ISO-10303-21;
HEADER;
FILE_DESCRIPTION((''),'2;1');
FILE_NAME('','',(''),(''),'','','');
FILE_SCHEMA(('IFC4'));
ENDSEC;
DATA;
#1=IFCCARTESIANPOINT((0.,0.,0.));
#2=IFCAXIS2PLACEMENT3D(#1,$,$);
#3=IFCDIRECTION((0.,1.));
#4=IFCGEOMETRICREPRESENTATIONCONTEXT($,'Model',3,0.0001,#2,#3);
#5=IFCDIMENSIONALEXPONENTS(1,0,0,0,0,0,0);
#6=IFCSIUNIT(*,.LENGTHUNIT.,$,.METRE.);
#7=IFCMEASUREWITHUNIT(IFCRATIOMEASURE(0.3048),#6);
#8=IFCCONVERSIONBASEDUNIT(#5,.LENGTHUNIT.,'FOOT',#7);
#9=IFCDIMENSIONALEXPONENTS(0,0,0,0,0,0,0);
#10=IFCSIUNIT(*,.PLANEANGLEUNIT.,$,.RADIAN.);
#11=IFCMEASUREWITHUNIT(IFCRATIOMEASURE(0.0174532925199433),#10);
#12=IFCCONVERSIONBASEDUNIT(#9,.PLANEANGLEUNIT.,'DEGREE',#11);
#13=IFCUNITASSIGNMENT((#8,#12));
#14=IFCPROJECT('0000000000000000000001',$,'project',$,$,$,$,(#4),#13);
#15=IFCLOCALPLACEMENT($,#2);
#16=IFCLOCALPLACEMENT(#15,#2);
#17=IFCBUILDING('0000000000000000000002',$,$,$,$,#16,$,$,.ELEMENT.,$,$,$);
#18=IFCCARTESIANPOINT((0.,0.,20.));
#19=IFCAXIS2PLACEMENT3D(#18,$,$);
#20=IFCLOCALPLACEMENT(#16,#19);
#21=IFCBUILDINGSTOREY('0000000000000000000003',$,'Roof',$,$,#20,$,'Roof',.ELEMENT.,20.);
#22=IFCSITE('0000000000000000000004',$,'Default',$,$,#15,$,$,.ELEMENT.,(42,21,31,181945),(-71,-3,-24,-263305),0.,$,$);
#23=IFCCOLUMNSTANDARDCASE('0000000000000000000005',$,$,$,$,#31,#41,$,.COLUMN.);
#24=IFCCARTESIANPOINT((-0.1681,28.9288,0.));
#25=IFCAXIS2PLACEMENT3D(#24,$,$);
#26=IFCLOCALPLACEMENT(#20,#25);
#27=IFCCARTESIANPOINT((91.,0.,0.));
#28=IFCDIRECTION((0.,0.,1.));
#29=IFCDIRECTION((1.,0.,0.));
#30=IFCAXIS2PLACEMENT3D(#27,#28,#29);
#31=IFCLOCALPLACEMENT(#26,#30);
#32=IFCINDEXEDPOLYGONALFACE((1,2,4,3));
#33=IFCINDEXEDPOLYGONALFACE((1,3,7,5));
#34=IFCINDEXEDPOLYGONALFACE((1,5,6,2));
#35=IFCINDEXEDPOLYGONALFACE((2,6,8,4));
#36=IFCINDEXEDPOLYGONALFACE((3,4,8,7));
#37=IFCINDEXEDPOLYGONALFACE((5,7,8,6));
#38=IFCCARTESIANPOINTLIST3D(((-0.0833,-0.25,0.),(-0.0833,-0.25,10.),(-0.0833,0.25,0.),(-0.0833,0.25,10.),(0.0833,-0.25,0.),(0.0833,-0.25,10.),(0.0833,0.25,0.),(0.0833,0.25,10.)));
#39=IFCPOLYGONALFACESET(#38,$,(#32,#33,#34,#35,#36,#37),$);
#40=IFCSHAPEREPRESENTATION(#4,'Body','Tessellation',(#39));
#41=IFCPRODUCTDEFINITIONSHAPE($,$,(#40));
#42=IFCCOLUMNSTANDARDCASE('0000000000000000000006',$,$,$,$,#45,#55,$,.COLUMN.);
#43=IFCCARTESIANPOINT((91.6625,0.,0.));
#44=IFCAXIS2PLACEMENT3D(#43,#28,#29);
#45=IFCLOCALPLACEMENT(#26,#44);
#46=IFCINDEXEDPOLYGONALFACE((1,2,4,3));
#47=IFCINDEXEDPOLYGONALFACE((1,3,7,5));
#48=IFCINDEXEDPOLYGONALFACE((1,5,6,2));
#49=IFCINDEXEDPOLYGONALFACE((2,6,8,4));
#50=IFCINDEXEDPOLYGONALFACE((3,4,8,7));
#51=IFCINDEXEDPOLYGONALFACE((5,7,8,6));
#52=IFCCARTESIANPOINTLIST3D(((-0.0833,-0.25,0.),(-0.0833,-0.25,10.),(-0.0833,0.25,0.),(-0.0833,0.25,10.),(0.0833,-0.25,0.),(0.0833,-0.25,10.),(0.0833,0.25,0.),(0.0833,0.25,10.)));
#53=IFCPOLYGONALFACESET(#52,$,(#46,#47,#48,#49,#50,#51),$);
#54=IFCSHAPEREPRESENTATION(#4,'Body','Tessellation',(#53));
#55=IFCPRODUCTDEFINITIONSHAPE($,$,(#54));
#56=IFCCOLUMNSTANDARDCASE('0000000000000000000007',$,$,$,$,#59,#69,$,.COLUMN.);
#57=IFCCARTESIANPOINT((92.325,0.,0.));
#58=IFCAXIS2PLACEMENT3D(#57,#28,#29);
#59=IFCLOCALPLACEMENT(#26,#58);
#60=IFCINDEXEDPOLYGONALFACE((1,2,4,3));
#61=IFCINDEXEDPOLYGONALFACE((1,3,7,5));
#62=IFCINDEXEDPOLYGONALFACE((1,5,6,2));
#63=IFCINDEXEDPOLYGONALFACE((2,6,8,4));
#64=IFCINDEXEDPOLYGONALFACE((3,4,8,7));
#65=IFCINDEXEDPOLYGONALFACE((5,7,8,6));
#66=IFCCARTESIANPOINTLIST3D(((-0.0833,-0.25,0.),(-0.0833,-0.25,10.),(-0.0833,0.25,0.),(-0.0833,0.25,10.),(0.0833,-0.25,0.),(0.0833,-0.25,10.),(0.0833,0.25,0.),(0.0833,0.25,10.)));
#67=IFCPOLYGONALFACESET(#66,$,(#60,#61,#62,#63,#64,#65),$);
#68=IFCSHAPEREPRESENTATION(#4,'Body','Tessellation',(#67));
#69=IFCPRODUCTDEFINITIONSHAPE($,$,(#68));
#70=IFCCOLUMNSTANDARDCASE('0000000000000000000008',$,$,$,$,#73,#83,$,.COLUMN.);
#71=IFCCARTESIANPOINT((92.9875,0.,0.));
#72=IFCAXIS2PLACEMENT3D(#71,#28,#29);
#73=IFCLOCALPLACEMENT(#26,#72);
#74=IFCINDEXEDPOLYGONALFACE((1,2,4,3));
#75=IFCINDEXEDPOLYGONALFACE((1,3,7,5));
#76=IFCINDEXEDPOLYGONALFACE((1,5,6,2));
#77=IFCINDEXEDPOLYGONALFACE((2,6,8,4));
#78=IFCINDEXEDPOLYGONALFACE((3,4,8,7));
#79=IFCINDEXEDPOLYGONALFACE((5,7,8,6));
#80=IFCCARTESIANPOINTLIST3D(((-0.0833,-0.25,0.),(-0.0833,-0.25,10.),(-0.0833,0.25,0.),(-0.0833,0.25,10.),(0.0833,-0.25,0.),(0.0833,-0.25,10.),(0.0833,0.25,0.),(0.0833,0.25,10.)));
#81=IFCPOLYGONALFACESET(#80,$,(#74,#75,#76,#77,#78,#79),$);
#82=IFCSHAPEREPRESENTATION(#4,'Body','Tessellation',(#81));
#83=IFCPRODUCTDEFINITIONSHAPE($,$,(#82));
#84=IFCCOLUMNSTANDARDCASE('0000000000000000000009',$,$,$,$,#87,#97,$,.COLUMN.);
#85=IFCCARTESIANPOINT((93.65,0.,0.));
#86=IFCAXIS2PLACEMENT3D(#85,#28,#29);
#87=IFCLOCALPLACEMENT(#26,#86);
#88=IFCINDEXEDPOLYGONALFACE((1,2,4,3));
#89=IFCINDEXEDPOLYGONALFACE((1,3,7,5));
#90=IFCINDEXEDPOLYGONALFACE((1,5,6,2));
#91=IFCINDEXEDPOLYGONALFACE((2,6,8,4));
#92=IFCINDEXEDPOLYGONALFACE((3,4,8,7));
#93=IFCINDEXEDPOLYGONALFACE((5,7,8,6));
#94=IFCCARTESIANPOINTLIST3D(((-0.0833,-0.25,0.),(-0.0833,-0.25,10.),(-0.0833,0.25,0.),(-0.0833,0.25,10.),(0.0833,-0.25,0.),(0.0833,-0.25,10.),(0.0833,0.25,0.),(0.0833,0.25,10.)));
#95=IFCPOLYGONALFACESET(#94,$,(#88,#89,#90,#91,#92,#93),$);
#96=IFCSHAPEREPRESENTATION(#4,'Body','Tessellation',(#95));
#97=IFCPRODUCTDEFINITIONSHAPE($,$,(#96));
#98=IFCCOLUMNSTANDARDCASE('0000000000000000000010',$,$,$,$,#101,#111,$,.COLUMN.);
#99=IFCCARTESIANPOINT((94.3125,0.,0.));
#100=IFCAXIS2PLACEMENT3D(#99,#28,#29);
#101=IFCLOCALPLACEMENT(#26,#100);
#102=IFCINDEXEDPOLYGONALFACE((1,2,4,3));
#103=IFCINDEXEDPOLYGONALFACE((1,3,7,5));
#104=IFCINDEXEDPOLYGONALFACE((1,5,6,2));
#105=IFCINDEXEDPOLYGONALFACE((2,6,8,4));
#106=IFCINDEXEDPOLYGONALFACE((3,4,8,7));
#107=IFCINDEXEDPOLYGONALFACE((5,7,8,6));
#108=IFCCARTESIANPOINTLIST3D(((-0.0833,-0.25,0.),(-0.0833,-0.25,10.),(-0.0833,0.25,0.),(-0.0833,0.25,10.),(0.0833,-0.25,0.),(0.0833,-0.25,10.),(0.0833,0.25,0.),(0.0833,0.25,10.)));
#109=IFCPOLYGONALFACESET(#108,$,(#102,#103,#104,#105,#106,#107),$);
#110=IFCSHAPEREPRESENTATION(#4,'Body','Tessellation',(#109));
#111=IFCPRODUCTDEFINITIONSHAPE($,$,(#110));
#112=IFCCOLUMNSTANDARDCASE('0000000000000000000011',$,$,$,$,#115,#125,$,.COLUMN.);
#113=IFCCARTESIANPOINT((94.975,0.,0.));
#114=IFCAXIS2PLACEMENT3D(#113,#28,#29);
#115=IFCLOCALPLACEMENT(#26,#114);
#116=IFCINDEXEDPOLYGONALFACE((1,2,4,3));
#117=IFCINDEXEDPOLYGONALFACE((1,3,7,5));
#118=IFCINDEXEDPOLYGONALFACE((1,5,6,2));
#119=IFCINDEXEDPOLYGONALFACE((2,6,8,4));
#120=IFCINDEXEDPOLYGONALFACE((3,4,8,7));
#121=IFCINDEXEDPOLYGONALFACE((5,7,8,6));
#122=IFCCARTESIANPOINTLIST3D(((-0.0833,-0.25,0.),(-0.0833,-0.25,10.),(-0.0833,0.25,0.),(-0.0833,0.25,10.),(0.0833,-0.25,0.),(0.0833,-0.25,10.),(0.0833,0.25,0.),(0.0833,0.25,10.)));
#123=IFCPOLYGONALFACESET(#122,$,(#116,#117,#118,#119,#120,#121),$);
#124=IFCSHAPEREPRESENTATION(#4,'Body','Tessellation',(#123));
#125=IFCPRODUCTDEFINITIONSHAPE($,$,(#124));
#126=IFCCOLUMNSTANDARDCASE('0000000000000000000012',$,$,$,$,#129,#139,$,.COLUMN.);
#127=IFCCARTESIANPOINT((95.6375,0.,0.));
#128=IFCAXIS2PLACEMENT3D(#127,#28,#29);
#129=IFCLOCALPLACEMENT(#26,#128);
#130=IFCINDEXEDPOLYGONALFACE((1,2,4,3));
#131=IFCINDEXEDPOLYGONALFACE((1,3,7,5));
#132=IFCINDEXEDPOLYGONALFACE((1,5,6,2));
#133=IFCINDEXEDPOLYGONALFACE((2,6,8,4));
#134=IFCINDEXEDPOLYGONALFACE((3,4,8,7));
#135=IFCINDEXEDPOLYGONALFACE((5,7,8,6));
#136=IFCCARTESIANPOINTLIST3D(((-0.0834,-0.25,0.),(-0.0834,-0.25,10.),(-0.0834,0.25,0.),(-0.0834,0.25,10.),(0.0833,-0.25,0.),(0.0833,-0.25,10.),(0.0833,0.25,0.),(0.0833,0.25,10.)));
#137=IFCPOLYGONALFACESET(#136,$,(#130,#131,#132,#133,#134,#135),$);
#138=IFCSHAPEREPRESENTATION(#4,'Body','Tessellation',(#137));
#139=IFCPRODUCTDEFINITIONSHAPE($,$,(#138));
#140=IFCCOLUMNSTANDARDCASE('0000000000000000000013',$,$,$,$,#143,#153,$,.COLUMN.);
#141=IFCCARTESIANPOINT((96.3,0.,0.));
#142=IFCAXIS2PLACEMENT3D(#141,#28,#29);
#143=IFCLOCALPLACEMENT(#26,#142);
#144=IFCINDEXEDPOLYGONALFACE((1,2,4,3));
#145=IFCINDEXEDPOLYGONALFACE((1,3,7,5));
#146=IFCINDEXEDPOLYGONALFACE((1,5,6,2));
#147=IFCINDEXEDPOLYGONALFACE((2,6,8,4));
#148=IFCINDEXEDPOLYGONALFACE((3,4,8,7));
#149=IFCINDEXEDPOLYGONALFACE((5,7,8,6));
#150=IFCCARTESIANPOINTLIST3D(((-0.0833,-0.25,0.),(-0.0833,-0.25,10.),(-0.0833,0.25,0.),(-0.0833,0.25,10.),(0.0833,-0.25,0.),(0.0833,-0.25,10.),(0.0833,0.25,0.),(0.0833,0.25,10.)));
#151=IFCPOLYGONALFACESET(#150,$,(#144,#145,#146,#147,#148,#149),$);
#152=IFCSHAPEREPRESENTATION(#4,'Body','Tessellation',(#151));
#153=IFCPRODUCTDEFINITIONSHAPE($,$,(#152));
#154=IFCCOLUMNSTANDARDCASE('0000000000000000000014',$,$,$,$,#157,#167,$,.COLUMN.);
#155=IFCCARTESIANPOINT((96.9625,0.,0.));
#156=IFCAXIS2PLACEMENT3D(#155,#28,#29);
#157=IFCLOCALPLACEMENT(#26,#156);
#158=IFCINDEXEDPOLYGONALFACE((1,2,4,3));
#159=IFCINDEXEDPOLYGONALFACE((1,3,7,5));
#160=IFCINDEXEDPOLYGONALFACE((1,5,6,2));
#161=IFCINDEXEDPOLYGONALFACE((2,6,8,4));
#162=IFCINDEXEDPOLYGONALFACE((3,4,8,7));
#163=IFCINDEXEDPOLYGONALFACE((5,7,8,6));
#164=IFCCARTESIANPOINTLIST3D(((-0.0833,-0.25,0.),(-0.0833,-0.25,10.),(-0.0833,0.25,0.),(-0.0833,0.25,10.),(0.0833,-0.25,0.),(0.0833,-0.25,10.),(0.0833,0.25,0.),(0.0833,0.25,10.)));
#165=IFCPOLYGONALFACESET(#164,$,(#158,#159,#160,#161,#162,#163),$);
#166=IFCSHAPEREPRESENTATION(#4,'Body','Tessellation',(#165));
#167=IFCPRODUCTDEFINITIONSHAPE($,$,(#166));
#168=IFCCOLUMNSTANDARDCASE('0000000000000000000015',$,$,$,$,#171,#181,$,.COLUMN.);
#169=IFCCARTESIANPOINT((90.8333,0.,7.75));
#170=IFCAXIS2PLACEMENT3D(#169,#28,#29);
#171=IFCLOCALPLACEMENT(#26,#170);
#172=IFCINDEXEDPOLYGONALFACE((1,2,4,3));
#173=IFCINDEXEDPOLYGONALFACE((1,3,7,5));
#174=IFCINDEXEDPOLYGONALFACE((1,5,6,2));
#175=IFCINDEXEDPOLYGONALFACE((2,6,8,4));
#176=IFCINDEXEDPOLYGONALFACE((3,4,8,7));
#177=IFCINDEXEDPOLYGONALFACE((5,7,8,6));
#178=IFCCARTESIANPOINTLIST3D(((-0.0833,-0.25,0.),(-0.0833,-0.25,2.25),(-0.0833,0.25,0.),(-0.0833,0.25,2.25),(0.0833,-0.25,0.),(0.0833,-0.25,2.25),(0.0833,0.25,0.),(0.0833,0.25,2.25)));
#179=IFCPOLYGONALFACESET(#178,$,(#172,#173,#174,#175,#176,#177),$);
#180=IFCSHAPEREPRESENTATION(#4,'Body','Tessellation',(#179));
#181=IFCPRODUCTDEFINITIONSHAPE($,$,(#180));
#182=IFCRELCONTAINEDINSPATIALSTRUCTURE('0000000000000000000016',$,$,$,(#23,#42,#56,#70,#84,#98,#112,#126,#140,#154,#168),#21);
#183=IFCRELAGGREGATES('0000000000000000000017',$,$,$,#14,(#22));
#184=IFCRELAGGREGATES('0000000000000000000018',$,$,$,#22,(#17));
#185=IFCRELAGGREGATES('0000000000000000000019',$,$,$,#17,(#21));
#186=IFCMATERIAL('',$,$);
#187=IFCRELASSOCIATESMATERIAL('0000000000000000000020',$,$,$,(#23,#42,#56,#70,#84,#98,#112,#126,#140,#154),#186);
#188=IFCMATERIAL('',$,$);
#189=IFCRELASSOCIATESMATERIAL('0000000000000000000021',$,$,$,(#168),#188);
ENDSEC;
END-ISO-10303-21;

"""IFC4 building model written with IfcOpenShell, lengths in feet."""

from ifc_helpers import new_model, entity, si_unit, converted_unit, direction, frame, origin, place, context, project, spatial, rectangle, extrude, material, element, save


model = new_model("IFC4")

# Units and contexts
model_context = context("Model", 3, precision=0.0001, world=origin(), true_north=direction((0.0, 1.0)))
ifc_project = project(units=[converted_unit("LENGTHUNIT", "FOOT", entity("IfcRatioMeasure", 0.3048), si_unit("LENGTHUNIT", "METRE"), dimensions=[1, 0, 0, 0, 0, 0, 0]), converted_unit("PLANEANGLEUNIT", "DEGREE", entity("IfcRatioMeasure", 0.0174532925199433), si_unit("PLANEANGLEUNIT", "RADIAN"), dimensions=[0, 0, 0, 0, 0, 0, 0])], contexts=[model_context])

# Site, building, storey
site_placement = place(None, origin())
site = spatial("IfcSite", under=ifc_project, at=site_placement, Name="Default", CompositionType="ELEMENT", RefLatitude=(42, 21, 31, 181945), RefLongitude=(-71, -3, -24, -263305), RefElevation=0.0)
building_placement = place(site_placement, origin())
building = spatial("IfcBuilding", under=site, at=building_placement, CompositionType="ELEMENT")
storey_placement = place(building_placement, frame((0.0, 0.0, 20.0)))
storey = spatial("IfcBuildingStorey", under=building, at=storey_placement, Name="Roof", LongName="Roof", CompositionType="ELEMENT", Elevation=20.0)

# Columns
ifc_material_1 = material(Name="")
placement = place(storey_placement, frame((-0.1681, 28.9288, 0.0)))
for number, where, z_axis, x_axis in (
    (1, (91.0, 0.0, 0.0), (0.0, 0.0, 1.0), (1.0, 0.0, 0.0)),
    (2, (91.6625, 0.0, 0.0), (0.0, 0.0, 1.0), (1.0, 0.0, 0.0)),
    (3, (92.325, 0.0, 0.0), (0.0, 0.0, 1.0), (1.0, 0.0, 0.0)),
    (4, (92.9875, 0.0, 0.0), (0.0, 0.0, 1.0), (1.0, 0.0, 0.0)),
    (5, (93.65, 0.0, 0.0), (0.0, 0.0, 1.0), (1.0, 0.0, 0.0)),
    (6, (94.3125, 0.0, 0.0), (0.0, 0.0, 1.0), (1.0, 0.0, 0.0)),
    (7, (94.975, 0.0, 0.0), (0.0, 0.0, 1.0), (1.0, 0.0, 0.0)),
    (8, (95.6375, 0.0, 0.0), (0.0, 0.0, 1.0), (1.0, 0.0, 0.0)),
    (9, (96.3, 0.0, 0.0), (0.0, 0.0, 1.0), (1.0, 0.0, 0.0)),
    (10, (96.9625, 0.0, 0.0), (0.0, 0.0, 1.0), (1.0, 0.0, 0.0)),
):
    element("IfcColumnStandardCase", number, at=place(placement, frame(where, z_axis=z_axis, x_axis=x_axis)), inside=storey, material=ifc_material_1, PredefinedType="COLUMN", context=model_context, shape_type="SweptSolid", body=[
        extrude(rectangle(XDim=0.1667, YDim=0.5), origin(), (0.0, 0.0, 1.0), 10.0),
    ])
ifc_material_2 = material(Name="")
for number, where, z_axis, x_axis in (
    (11, (90.8333, 0.0, 7.75), (0.0, 0.0, 1.0), (1.0, 0.0, 0.0)),
):
    element("IfcColumnStandardCase", number, at=place(placement, frame(where, z_axis=z_axis, x_axis=x_axis)), inside=storey, material=ifc_material_2, PredefinedType="COLUMN", context=model_context, shape_type="SweptSolid", body=[
        extrude(rectangle(XDim=0.1667, YDim=0.5), origin(), (0.0, 0.0, 1.0), 2.25),
    ])

save(model, "model.ifc")
